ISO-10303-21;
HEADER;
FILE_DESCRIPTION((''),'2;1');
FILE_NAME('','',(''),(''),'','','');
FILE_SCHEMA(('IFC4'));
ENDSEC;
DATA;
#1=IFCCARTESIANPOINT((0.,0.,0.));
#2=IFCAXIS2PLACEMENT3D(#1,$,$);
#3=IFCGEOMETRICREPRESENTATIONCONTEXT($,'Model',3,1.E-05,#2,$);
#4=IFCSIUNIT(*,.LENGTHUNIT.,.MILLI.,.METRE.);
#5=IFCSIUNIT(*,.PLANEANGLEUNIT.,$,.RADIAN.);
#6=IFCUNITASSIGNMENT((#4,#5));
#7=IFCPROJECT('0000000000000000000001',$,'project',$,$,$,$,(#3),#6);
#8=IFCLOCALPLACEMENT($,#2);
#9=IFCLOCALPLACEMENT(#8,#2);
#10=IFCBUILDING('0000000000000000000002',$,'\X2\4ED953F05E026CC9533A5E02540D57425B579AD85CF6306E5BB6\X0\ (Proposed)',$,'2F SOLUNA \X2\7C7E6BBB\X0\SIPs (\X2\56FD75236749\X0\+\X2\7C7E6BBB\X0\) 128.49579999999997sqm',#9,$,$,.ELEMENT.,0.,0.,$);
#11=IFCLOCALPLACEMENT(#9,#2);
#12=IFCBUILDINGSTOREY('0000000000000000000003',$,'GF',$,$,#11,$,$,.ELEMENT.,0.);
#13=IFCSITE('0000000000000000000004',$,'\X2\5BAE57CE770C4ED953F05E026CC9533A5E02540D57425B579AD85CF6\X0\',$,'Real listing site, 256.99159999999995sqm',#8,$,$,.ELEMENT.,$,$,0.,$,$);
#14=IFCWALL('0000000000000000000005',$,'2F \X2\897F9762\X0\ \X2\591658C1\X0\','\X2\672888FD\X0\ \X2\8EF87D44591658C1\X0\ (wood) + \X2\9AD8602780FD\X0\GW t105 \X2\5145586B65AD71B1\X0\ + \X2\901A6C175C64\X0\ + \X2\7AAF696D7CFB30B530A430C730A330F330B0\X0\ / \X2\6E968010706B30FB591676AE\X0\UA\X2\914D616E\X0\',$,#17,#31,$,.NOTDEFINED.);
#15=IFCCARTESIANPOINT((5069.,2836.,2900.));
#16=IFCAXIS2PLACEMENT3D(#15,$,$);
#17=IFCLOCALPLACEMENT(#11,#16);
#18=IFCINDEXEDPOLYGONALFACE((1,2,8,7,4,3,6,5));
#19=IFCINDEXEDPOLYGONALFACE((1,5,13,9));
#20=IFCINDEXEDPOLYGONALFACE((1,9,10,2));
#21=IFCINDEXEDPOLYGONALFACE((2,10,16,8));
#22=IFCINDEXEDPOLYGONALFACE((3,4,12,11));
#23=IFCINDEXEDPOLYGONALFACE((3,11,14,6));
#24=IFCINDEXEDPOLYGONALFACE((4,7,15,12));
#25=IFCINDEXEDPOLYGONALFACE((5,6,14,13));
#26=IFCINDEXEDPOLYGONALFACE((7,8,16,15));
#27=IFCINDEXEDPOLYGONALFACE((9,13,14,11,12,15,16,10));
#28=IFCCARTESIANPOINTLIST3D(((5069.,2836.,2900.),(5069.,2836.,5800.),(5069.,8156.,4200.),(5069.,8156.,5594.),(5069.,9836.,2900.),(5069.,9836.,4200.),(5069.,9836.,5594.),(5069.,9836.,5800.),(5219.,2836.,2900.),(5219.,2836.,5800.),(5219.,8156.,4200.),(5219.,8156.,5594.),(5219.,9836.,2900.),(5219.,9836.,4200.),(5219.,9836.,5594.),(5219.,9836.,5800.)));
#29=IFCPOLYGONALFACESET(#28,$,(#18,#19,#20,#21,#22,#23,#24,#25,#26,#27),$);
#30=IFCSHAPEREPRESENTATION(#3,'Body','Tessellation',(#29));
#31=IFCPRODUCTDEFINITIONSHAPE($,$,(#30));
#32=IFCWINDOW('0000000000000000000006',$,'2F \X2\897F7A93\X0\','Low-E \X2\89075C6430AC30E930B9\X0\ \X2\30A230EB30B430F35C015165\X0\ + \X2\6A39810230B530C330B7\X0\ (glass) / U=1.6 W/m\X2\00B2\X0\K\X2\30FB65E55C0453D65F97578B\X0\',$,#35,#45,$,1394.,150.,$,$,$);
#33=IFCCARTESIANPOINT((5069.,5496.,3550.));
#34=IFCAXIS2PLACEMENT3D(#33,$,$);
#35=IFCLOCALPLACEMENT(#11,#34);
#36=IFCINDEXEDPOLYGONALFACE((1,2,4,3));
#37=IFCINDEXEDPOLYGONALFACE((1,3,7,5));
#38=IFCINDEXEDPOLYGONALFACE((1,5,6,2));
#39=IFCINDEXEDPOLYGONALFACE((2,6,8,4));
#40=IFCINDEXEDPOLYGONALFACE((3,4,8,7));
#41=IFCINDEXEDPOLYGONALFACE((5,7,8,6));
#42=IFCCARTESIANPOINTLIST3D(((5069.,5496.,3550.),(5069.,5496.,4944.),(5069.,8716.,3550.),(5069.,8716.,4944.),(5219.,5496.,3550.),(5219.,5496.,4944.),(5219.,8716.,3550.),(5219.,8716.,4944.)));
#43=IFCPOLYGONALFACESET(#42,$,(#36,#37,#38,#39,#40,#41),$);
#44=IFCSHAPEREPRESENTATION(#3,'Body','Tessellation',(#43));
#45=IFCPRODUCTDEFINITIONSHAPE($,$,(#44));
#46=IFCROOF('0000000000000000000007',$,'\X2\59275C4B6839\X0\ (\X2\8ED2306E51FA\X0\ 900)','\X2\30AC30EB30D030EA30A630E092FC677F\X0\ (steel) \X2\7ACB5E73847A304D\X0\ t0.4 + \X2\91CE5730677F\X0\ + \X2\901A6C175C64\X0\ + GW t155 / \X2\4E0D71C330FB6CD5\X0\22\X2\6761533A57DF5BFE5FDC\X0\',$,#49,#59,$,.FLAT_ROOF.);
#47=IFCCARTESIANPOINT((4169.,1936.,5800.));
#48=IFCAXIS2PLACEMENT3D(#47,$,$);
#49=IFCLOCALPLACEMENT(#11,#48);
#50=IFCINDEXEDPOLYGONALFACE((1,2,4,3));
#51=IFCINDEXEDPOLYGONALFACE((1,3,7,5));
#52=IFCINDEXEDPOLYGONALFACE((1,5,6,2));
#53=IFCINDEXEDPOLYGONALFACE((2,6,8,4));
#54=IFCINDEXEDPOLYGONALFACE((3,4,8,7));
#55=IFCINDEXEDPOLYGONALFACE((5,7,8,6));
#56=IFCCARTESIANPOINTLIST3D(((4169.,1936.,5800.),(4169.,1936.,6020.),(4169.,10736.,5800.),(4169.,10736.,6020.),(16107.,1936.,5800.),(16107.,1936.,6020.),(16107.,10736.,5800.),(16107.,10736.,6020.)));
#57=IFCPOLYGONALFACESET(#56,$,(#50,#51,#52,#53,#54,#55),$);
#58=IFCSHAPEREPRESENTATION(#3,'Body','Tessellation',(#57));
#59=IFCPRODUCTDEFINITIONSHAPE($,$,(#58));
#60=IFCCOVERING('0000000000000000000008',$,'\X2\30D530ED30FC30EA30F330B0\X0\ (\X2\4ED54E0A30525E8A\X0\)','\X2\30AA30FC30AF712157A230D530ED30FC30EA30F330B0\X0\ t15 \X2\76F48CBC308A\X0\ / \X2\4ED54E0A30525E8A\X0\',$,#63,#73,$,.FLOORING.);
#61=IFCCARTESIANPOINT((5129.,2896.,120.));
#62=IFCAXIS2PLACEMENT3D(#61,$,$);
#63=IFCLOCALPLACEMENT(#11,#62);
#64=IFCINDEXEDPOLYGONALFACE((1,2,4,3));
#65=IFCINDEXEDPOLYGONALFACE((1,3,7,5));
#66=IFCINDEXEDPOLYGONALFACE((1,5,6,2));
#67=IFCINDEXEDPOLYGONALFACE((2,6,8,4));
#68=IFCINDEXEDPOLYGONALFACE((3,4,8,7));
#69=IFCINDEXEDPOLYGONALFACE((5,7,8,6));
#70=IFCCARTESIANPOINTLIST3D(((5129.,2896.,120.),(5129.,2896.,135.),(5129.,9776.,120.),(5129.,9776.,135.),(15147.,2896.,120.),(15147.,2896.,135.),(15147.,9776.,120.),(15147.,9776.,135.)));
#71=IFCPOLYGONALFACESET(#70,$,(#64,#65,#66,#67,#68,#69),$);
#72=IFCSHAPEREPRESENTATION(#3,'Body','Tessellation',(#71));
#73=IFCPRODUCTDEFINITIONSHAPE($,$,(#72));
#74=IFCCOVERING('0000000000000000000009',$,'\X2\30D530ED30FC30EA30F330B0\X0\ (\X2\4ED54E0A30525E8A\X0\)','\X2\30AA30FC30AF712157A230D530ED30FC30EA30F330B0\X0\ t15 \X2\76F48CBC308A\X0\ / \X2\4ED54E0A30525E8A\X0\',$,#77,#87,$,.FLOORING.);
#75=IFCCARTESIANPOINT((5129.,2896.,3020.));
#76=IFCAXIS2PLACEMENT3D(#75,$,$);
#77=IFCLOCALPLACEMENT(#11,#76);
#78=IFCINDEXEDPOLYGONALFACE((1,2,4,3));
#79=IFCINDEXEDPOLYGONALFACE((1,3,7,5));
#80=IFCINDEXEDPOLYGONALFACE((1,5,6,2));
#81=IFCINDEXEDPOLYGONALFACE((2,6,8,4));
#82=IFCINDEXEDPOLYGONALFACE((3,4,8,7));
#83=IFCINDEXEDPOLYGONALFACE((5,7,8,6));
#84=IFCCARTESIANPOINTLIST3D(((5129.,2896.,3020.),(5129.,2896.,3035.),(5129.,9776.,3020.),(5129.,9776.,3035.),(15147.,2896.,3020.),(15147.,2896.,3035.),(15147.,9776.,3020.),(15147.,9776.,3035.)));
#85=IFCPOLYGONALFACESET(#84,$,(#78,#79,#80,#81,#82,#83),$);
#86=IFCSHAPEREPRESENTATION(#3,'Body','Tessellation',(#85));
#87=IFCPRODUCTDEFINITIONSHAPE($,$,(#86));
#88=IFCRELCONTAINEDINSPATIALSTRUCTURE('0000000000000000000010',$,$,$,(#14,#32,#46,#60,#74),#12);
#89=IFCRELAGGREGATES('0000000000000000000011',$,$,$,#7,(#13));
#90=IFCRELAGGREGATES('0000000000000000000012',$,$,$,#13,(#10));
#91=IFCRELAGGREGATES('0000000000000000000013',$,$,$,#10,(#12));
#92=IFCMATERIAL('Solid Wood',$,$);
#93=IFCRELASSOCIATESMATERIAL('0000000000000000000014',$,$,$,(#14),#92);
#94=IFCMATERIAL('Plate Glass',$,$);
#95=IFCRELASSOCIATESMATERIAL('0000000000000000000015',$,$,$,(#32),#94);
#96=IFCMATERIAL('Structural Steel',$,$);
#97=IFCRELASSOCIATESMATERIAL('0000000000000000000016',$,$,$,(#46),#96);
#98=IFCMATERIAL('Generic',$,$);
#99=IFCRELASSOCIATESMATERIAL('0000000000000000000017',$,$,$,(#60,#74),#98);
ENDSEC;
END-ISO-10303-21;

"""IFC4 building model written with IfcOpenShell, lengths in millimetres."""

from ifc_helpers import new_model, si_unit, frame, frame_2d, origin, place, context, project, spatial, rectangle, extrude, material, element, fill, save


model = new_model("IFC4")

# Units and contexts
model_context = context("Model", 3, precision=1e-05, world=origin())
ifc_project = project(units=[si_unit("LENGTHUNIT", "METRE", prefix="MILLI"), si_unit("PLANEANGLEUNIT", "RADIAN")], contexts=[model_context])

# Site, building, storey
site_placement = place(None, origin())
site = spatial("IfcSite", under=ifc_project, at=site_placement, Name="宮城県仙台市泉区市名坂字高島", ObjectType="Real listing site, 256.99159999999995sqm", CompositionType="ELEMENT", RefElevation=0.0)
building_placement = place(site_placement, origin())
building = spatial("IfcBuilding", under=site, at=building_placement, Name="仙台市泉区市名坂字高島の家 (Proposed)", ObjectType="2F SOLUNA 籾殻SIPs (国産杉+籾殻) 128.49579999999997sqm", CompositionType="ELEMENT", ElevationOfRefHeight=0.0, ElevationOfTerrain=0.0)
storey_placement = place(building_placement, origin())
storey = spatial("IfcBuildingStorey", under=building, at=storey_placement, Name="GF", CompositionType="ELEMENT", Elevation=0.0)

# Shared definitions
ifc_material_1 = material(Name="Solid Wood")

# Shared definitions
ifc_material_2 = material(Name="Plate Glass")

# Wall, opening, window
wall_1_placement = place(storey_placement, frame((5069.0, 2836.0, 2900.0)))
wall_1 = element("IfcWall", 1, at=wall_1_placement, inside=storey, material=ifc_material_1, Name="2F 西面 外壁", Description="木製 軸組外壁 (wood) + 高性能GW t105 充填断熱 + 通気層 + 窯業系サイディング / 準耐火・外皮UA配慮", PredefinedType="NOTDEFINED", context=model_context, shape_type="SweptSolid", body=[
    extrude(rectangle(XDim=150.0, YDim=7000.0, at=frame_2d((75.0, 3500.0))), frame((5069.0, 2836.0, 2900.0)), (0.0, 0.0, 1.0), 2900.0),
])
opening_1_placement = place(storey_placement, frame((5069.0, 5496.0, 3550.0)))
opening_1 = element("IfcOpeningElement", 2, at=opening_1_placement, cuts=wall_1, PredefinedType="NOTDEFINED", context=model_context, shape_type="SweptSolid", body=[
    extrude(rectangle(XDim=150.0, YDim=3220.0, at=frame_2d((75.0, 1610.0))), frame((5069.0, 5496.0, 3550.0)), (0.0, 0.0, 1.0), 1394.0),
])
window_1_placement = place(storey_placement, frame((5069.0, 5496.0, 3550.0)))
window_1 = element("IfcWindow", 3, at=window_1_placement, inside=storey, material=ifc_material_2, Name="2F 西窓", Description="Low-E 複層ガラス アルゴン封入 + 樹脂サッシ (glass) / U=1.6 W/m²K・日射取得型", OverallHeight=1394.0, OverallWidth=150.0, context=model_context, shape_type="SweptSolid", body=[
    extrude(rectangle(XDim=150.0, YDim=3220.0, at=frame_2d((75.0, 1610.0))), frame((5069.0, 5496.0, 3550.0)), (0.0, 0.0, 1.0), 1394.0),
])
fill(opening_1, window_1)

# Roof
ifc_material_3 = material(Name="Structural Steel")
roof_placement = place(storey_placement, frame((4169.0, 1936.0, 5800.0)))
element("IfcRoof", 4, at=roof_placement, inside=storey, material=ifc_material_3, Name="大屋根 (軒の出 900)", Description="ガルバリウム鋼板 (steel) 立平葺き t0.4 + 野地板 + 通気層 + GW t155 / 不燃・法22条区域対応", PredefinedType="FLAT_ROOF", context=model_context, shape_type="SweptSolid", body=[
    extrude(rectangle(XDim=11938.0, YDim=8800.0, at=frame_2d((5969.0, 4400.0))), frame((4169.0, 1936.0, 5800.0)), (0.0, 0.0, 1.0), 220.0),
])

# Coverings
ifc_material_4 = material(Name="Generic")
covering_1_placement = place(storey_placement, frame((5129.0, 2896.0, 120.0)))
element("IfcCovering", 5, at=covering_1_placement, inside=storey, material=ifc_material_4, Name="フローリング (仕上げ床)", Description="オーク無垢フローリング t15 直貼り / 仕上げ床", PredefinedType="FLOORING", context=model_context, shape_type="SweptSolid", body=[
    extrude(rectangle(XDim=10018.0, YDim=6880.0, at=frame_2d((5009.0, 3440.0))), frame((5129.0, 2896.0, 120.0)), (0.0, 0.0, 1.0), 15.0),
])
covering_2_placement = place(storey_placement, frame((5129.0, 2896.0, 3020.0)))
element("IfcCovering", 6, at=covering_2_placement, inside=storey, material=ifc_material_4, Name="フローリング (仕上げ床)", Description="オーク無垢フローリング t15 直貼り / 仕上げ床", PredefinedType="FLOORING", context=model_context, shape_type="SweptSolid", body=[
    extrude(rectangle(XDim=10018.0, YDim=6880.0, at=frame_2d((5009.0, 3440.0))), frame((5129.0, 2896.0, 3020.0)), (0.0, 0.0, 1.0), 15.0),
])

save(model, "model.ifc")
